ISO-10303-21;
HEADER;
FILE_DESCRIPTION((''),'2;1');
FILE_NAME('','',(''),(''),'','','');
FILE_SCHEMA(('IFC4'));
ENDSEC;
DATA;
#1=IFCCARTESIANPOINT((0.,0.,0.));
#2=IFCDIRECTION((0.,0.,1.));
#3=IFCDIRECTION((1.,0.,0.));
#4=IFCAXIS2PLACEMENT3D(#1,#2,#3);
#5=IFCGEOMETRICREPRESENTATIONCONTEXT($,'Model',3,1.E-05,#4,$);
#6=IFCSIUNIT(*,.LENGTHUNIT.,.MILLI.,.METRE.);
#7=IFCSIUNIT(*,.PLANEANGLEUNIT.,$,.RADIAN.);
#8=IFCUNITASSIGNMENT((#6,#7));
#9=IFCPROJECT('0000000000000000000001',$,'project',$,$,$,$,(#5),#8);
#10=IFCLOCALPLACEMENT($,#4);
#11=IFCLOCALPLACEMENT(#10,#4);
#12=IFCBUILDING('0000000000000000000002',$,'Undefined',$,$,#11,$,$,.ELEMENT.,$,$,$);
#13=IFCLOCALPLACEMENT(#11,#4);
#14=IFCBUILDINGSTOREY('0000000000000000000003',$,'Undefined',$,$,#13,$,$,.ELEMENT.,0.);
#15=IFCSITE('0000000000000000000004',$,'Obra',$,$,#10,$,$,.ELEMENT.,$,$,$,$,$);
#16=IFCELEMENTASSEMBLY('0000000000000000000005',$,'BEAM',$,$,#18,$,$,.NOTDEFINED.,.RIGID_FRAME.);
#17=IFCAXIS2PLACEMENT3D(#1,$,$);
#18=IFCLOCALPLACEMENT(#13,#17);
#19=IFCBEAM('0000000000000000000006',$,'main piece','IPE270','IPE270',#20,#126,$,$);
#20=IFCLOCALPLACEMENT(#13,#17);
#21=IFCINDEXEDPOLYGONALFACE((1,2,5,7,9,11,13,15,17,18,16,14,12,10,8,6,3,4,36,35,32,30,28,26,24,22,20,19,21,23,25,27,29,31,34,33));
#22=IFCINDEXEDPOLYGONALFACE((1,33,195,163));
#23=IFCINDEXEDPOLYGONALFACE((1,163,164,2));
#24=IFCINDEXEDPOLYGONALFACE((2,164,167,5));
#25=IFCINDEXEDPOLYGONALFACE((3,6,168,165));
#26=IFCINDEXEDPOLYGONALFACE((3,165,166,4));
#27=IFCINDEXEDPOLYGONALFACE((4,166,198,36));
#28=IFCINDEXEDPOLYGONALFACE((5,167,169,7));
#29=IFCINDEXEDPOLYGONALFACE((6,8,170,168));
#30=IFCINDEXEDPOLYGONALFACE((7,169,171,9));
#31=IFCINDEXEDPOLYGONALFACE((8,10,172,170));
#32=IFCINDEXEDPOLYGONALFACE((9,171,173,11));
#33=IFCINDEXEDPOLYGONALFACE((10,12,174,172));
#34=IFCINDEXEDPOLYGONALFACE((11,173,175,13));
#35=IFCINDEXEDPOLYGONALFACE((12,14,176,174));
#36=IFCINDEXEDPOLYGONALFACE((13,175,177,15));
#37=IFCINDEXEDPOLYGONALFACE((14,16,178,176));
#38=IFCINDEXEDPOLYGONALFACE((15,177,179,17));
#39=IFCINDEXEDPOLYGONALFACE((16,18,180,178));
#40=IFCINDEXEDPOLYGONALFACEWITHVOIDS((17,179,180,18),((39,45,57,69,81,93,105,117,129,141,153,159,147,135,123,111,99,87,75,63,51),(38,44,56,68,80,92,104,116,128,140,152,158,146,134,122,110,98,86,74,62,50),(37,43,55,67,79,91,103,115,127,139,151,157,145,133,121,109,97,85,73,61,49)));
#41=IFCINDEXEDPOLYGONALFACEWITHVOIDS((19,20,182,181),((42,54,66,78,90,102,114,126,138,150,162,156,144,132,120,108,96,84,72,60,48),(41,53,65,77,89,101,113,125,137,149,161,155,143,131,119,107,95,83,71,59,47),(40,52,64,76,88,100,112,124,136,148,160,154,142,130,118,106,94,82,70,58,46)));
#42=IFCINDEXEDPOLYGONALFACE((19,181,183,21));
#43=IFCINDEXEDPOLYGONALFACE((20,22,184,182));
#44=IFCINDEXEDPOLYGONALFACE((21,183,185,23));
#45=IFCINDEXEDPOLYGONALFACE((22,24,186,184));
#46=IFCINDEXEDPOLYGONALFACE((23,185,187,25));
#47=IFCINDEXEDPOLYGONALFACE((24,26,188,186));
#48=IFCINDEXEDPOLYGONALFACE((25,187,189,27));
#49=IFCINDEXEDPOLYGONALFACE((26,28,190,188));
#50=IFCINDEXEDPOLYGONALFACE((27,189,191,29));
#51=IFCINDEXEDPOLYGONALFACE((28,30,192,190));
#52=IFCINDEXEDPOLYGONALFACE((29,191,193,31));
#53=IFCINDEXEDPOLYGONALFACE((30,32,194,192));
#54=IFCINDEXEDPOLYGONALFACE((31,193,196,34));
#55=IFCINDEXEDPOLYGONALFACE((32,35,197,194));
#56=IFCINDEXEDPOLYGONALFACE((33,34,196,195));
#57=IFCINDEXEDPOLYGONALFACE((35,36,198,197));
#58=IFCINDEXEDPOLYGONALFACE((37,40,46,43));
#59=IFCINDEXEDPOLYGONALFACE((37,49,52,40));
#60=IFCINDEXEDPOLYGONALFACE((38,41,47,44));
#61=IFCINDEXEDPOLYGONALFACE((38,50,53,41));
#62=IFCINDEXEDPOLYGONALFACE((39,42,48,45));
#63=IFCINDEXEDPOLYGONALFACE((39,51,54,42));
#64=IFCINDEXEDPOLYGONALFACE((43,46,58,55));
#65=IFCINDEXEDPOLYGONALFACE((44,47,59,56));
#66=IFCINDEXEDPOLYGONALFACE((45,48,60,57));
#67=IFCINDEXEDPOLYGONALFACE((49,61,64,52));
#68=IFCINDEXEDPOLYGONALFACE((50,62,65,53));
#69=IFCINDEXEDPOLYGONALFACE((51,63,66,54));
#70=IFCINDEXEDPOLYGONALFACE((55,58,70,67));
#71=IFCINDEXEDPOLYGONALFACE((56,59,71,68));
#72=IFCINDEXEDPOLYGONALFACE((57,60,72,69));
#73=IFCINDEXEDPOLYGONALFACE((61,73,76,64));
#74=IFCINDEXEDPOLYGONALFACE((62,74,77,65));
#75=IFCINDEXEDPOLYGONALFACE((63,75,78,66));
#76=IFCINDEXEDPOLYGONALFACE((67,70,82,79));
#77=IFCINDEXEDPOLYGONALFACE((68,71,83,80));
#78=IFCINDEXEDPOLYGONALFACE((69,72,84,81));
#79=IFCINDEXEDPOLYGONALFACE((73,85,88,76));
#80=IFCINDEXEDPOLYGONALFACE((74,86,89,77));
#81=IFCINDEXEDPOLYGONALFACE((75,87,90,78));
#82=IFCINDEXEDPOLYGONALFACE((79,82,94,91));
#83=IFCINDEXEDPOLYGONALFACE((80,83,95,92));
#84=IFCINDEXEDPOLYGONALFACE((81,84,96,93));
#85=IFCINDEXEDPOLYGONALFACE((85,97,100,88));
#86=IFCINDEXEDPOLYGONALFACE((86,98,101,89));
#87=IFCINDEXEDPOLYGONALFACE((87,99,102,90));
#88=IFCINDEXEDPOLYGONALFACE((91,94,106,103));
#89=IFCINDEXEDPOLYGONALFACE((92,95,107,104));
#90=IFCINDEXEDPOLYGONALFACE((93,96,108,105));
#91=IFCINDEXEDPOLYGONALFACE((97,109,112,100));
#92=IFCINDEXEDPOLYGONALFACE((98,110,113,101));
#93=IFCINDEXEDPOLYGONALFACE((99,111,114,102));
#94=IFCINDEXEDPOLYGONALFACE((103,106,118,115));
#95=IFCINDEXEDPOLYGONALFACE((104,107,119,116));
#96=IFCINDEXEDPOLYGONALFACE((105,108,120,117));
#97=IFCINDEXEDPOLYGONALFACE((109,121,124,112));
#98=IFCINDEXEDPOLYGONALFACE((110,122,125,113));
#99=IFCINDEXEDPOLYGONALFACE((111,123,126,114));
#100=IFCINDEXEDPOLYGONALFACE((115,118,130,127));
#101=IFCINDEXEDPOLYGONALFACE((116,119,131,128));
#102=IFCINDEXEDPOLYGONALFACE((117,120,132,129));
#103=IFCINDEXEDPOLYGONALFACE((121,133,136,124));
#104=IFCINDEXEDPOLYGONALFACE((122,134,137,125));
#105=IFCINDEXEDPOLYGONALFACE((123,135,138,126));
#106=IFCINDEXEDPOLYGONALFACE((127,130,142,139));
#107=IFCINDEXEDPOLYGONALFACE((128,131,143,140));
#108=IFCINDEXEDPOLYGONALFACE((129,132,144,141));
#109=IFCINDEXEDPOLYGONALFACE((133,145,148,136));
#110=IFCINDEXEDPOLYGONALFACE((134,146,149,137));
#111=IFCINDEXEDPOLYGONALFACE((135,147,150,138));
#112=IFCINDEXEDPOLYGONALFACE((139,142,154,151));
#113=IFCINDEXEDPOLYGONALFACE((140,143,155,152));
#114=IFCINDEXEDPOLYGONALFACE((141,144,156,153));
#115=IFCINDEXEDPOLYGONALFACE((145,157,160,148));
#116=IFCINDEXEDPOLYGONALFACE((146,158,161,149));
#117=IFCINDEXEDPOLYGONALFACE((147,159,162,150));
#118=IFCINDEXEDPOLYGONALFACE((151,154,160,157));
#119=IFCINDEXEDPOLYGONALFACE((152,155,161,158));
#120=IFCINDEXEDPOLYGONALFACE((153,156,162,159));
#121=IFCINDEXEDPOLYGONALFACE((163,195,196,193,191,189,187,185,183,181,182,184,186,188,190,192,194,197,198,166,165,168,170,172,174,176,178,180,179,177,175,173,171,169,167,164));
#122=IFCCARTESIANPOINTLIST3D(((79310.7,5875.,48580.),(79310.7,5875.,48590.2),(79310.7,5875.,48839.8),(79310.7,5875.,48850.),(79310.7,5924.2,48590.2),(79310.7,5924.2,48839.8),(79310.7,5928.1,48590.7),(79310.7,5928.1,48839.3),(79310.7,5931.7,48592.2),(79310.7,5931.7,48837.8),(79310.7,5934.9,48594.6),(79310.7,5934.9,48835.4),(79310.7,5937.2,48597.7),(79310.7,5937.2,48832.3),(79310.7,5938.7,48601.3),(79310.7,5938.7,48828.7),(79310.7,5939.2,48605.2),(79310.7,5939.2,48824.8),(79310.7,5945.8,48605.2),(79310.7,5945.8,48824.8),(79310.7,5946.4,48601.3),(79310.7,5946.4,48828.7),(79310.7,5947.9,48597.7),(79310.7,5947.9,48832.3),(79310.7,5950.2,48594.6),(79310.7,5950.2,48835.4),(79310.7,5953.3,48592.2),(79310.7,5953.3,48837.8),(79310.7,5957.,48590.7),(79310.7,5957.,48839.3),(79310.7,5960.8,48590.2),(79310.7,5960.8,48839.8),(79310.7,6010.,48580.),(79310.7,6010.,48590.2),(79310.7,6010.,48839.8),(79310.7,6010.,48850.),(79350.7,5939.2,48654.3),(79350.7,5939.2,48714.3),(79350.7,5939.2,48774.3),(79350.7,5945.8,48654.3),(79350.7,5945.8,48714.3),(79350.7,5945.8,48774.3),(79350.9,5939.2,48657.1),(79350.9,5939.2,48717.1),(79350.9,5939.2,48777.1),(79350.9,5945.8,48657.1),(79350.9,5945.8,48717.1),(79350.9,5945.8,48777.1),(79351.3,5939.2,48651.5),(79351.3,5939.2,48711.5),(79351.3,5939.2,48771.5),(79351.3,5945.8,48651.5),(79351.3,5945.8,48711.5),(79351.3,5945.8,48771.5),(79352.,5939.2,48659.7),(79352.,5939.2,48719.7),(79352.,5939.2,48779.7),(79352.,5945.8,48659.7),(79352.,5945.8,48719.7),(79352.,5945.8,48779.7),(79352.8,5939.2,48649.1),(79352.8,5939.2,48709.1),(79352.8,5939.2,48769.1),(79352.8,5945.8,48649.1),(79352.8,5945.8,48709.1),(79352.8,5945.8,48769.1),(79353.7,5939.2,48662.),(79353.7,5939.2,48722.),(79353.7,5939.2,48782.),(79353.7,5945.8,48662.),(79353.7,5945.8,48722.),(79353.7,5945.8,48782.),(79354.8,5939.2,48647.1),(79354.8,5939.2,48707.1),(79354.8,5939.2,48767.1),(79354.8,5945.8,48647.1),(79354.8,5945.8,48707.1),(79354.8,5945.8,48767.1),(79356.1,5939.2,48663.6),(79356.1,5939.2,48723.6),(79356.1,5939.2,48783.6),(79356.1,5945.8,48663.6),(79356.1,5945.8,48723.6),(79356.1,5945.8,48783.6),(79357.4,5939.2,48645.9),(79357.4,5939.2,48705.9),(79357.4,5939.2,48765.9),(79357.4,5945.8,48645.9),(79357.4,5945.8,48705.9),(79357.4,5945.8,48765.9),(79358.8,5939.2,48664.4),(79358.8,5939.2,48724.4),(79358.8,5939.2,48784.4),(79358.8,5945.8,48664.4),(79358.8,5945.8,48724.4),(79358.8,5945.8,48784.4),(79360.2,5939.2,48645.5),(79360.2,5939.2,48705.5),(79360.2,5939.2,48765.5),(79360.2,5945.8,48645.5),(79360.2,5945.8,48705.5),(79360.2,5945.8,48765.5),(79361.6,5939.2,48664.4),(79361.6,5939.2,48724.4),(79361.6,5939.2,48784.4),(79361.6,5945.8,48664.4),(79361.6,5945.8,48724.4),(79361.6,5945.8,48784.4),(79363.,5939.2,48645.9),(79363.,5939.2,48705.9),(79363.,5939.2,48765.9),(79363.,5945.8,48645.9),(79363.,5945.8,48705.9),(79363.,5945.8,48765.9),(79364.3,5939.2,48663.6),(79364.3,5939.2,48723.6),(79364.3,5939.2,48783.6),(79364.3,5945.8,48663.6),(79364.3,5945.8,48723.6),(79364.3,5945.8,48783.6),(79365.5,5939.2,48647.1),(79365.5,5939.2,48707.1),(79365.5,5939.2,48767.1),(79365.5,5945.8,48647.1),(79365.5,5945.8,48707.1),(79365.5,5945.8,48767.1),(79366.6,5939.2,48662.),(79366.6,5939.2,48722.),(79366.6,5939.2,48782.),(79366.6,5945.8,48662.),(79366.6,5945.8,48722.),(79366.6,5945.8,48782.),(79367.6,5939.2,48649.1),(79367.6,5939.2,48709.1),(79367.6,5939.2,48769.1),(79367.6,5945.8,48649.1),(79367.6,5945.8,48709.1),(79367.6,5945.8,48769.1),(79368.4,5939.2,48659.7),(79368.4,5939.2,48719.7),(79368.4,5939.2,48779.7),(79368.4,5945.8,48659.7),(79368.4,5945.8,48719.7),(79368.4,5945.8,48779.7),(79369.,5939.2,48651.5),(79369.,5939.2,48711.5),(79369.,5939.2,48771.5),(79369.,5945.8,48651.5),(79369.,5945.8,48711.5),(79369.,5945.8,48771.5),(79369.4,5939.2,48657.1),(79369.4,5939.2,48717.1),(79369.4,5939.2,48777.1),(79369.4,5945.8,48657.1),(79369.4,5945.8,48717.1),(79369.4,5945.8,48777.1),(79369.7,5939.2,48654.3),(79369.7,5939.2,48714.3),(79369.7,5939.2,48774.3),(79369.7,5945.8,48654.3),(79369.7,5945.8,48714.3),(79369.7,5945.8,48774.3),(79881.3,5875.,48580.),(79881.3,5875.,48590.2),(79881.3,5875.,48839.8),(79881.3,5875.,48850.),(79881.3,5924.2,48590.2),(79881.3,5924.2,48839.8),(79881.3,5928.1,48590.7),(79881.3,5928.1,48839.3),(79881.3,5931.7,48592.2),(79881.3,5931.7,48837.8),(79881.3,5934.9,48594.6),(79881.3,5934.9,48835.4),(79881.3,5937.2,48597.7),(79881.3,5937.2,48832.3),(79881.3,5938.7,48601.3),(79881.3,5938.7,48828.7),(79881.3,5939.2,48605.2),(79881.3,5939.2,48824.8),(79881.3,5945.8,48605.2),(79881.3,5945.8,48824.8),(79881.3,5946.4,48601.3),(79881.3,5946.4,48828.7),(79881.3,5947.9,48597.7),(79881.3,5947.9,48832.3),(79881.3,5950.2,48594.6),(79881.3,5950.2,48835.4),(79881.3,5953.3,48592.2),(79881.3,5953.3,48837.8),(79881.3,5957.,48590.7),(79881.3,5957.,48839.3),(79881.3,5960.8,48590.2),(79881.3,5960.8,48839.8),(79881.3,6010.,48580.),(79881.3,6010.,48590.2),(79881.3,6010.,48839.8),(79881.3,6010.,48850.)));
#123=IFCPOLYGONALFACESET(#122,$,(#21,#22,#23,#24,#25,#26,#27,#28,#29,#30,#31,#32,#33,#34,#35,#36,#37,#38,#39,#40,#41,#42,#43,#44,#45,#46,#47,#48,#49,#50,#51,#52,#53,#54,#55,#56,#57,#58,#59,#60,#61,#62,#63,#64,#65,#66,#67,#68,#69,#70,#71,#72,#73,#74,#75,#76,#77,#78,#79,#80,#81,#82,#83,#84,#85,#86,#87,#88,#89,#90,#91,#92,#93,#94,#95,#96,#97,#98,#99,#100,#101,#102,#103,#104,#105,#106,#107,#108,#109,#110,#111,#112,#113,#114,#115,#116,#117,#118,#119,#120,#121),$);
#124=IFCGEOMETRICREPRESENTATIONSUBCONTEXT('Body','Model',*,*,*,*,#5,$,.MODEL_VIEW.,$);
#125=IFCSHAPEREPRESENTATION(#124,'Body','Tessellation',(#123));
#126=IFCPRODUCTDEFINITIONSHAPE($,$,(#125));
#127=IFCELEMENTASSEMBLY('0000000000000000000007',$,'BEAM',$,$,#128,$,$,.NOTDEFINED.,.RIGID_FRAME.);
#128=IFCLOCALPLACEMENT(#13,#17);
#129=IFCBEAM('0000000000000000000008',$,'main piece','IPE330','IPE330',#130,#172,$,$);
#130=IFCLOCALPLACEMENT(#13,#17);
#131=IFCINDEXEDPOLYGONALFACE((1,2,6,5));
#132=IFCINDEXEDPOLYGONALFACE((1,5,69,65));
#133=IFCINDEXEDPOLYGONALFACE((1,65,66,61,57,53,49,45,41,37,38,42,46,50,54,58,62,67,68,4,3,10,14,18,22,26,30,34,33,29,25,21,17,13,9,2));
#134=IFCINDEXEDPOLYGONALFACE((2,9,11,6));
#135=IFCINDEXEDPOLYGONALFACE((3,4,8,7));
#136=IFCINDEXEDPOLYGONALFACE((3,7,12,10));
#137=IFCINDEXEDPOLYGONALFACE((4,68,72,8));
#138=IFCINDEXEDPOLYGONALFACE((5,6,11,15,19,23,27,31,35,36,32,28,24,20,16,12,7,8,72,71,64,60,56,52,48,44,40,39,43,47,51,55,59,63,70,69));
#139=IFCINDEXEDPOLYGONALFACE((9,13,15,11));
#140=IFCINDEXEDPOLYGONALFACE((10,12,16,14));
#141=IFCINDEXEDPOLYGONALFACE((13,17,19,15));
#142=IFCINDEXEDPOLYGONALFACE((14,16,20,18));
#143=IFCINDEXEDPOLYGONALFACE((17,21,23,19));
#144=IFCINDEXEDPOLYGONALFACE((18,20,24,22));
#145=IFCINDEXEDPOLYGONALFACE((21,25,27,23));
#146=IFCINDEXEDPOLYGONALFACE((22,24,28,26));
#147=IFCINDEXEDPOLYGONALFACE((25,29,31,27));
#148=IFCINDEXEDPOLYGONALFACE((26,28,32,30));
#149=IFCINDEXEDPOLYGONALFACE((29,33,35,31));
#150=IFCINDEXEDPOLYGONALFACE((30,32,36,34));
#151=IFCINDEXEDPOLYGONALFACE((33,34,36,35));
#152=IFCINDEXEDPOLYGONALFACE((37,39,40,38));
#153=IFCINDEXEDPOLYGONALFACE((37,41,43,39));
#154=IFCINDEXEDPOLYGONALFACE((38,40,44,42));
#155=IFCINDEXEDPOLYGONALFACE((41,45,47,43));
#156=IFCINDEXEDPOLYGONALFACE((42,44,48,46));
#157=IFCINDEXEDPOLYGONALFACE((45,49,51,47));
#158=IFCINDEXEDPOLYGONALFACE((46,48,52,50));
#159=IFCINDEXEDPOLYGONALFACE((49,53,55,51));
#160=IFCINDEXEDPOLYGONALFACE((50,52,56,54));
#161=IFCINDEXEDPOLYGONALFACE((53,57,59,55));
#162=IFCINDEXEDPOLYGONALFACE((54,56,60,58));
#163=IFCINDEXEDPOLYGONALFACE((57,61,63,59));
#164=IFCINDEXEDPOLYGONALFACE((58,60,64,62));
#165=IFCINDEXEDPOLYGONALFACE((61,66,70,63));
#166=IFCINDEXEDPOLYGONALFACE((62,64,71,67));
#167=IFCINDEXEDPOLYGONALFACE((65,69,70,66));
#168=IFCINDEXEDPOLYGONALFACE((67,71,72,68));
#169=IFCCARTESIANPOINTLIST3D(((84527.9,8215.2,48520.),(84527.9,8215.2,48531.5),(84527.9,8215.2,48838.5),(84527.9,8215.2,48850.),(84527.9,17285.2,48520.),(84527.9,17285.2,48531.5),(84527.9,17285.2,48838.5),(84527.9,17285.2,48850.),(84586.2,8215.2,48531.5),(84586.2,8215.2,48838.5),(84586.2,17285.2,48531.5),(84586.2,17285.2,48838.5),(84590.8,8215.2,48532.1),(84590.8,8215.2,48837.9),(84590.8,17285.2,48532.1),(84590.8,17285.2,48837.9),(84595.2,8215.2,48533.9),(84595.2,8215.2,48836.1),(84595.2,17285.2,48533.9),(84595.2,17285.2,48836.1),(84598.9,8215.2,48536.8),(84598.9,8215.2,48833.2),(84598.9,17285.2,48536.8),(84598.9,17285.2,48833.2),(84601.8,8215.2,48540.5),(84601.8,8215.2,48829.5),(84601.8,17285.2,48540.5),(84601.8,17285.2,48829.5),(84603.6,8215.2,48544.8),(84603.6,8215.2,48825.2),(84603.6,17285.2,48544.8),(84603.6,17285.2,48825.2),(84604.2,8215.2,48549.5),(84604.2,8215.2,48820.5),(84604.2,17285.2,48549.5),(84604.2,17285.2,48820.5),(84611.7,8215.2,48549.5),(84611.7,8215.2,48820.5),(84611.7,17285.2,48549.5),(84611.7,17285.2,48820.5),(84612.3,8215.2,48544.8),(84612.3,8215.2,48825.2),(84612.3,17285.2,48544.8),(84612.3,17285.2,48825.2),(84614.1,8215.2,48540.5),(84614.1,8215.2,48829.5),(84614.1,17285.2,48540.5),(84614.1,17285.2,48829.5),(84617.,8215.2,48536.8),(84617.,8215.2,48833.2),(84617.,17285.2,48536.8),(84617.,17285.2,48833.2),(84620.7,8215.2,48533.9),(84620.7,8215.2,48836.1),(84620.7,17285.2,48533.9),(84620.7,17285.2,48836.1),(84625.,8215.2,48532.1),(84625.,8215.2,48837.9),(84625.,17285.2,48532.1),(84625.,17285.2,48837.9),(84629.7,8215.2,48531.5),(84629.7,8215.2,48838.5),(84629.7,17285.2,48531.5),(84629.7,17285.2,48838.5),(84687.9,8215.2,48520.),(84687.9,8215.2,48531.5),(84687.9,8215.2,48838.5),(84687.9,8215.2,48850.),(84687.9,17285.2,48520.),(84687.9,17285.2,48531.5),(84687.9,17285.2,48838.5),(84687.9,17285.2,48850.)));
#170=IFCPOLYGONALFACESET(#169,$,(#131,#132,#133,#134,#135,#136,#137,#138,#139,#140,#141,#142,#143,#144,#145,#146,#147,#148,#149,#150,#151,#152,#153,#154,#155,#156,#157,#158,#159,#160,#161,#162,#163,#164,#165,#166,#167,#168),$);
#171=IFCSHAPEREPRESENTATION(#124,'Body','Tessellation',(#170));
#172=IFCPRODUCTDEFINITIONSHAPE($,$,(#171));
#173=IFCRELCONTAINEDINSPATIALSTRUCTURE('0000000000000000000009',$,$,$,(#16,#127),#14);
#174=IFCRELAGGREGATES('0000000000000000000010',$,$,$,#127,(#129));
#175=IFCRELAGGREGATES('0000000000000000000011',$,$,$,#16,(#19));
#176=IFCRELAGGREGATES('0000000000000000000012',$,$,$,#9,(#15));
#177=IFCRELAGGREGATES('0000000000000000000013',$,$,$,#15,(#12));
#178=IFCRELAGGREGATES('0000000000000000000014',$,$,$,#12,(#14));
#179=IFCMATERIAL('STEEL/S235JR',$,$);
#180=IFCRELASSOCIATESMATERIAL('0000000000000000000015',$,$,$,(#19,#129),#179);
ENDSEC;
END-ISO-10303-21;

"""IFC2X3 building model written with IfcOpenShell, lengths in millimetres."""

from ifc_helpers import new_model, si_unit, frame, origin_with_axes, origin_2d_with_axis, place, context, subcontext, project, spatial, circle, i_section, extrude, clip, halfspace, source, transform, mapped, material, element, aggregate, save


model = new_model("IFC2X3")

# Units and contexts
model_context = context("Model", 3, precision=1e-05, world=origin_with_axes())
body_context = subcontext(model_context, "Body", "Model", "MODEL_VIEW")
ifc_project = project(units=[si_unit("LENGTHUNIT", "METRE", prefix="MILLI"), si_unit("PLANEANGLEUNIT", "RADIAN")], contexts=[model_context])

# Site, building, storey
site_placement = place(None, origin_with_axes())
site = spatial("IfcSite", under=ifc_project, at=site_placement, Name="Obra", CompositionType="ELEMENT")
building_placement = place(site_placement, origin_with_axes())
building = spatial("IfcBuilding", under=site, at=building_placement, Name="Undefined", CompositionType="ELEMENT")
storey_placement = place(building_placement, origin_with_axes())
storey = spatial("IfcBuildingStorey", under=building, at=storey_placement, Name="Undefined", CompositionType="ELEMENT", Elevation=0.0)

# Shared definitions
ifc_material_1 = material(Name="STEEL/S235JR")

# Element assembly, beam, opening
assembly_1_placement = place(storey_placement, origin_with_axes())
assembly_1 = element("IfcElementAssembly", 1, at=assembly_1_placement, inside=storey, Name="BEAM", AssemblyPlace="NOTDEFINED", PredefinedType="RIGID_FRAME")
beam_1_placement = place(assembly_1_placement, frame((78913.0, 5942.5, 48715.0), z_axis=(0.0, 0.0, 1.0), x_axis=(1.0, 0.0, 0.0)))
beam_1 = element("IfcBeam", 2, at=beam_1_placement, material=ifc_material_1, Name="main piece", Description="IPE270", ObjectType="IPE270", context=body_context, shape_type="Clipping", body=[
    clip(extrude(i_section(OverallWidth=135.0, OverallDepth=270.0, WebThickness=6.6, FlangeThickness=10.2, FilletRadius=15.0, at=origin_2d_with_axis()), frame((968.3, 0.0, 0.0), z_axis=(-1.0, 0.0, 0.0), x_axis=(0.0, -1.0, 0.0)), (0.0, 0.0, 1.0), 968.3), halfspace(frame((397.6, 60.0, -120.0), z_axis=(-1.0, -0.000019, 0.0), x_axis=(0.0, 0.0, 1.0)), False)),
])
shared_shape_1 = source(origin_with_axes(), body_context, "Body", "SweptSolid", [
    extrude(circle(Radius=9.5, at=origin_2d_with_axis()), frame((0.0, -3.4, 0.0), z_axis=(0.0, 1.0, 0.0), x_axis=(1.0, 0.0, 0.0)), (0.0, 0.0, 1.0), 6.8),
])
opening_1_placement = place(assembly_1_placement, frame((79310.2, 5942.5, 48835.0), z_axis=(1.0, 0.0, 0.0), x_axis=(0.0, 0.0, -1.0)))
element("IfcOpeningElement", 3, at=opening_1_placement, cuts=beam_1, ObjectType="Opening", context=body_context, shape_type="MappedRepresentation", body=[
    mapped(shared_shape_1, transform((60.0, 0.0, 50.0))),
    mapped(shared_shape_1, transform((120.0, 0.0, 50.0))),
    mapped(shared_shape_1, transform((180.0, 0.0, 50.0))),
])

# Element assembly, beam
assembly_2_placement = place(storey_placement, origin_with_axes())
assembly_2 = element("IfcElementAssembly", 4, at=assembly_2_placement, inside=storey, Name="BEAM", AssemblyPlace="NOTDEFINED", PredefinedType="RIGID_FRAME")
beam_2_placement = place(assembly_2_placement, frame((84607.9, 8215.2, 48685.0), z_axis=(0.0, 0.0, 1.0), x_axis=(0.0, 1.0, 0.0)))
beam_2 = element("IfcBeam", 5, at=beam_2_placement, material=ifc_material_1, Name="main piece", Description="IPE330", ObjectType="IPE330", context=body_context, shape_type="SweptSolid", body=[
    extrude(i_section(OverallWidth=160.0, OverallDepth=330.0, WebThickness=7.5, FlangeThickness=11.5, FilletRadius=18.0, at=origin_2d_with_axis()), frame((9070.0, 0.0, 0.0), z_axis=(-1.0, 0.0, 0.0), x_axis=(0.0, -1.0, 0.0)), (0.0, 0.0, 1.0), 9070.0),
])
aggregate(assembly_2, [beam_2])

aggregate(assembly_1, [beam_1])

save(model, "model.ifc")
